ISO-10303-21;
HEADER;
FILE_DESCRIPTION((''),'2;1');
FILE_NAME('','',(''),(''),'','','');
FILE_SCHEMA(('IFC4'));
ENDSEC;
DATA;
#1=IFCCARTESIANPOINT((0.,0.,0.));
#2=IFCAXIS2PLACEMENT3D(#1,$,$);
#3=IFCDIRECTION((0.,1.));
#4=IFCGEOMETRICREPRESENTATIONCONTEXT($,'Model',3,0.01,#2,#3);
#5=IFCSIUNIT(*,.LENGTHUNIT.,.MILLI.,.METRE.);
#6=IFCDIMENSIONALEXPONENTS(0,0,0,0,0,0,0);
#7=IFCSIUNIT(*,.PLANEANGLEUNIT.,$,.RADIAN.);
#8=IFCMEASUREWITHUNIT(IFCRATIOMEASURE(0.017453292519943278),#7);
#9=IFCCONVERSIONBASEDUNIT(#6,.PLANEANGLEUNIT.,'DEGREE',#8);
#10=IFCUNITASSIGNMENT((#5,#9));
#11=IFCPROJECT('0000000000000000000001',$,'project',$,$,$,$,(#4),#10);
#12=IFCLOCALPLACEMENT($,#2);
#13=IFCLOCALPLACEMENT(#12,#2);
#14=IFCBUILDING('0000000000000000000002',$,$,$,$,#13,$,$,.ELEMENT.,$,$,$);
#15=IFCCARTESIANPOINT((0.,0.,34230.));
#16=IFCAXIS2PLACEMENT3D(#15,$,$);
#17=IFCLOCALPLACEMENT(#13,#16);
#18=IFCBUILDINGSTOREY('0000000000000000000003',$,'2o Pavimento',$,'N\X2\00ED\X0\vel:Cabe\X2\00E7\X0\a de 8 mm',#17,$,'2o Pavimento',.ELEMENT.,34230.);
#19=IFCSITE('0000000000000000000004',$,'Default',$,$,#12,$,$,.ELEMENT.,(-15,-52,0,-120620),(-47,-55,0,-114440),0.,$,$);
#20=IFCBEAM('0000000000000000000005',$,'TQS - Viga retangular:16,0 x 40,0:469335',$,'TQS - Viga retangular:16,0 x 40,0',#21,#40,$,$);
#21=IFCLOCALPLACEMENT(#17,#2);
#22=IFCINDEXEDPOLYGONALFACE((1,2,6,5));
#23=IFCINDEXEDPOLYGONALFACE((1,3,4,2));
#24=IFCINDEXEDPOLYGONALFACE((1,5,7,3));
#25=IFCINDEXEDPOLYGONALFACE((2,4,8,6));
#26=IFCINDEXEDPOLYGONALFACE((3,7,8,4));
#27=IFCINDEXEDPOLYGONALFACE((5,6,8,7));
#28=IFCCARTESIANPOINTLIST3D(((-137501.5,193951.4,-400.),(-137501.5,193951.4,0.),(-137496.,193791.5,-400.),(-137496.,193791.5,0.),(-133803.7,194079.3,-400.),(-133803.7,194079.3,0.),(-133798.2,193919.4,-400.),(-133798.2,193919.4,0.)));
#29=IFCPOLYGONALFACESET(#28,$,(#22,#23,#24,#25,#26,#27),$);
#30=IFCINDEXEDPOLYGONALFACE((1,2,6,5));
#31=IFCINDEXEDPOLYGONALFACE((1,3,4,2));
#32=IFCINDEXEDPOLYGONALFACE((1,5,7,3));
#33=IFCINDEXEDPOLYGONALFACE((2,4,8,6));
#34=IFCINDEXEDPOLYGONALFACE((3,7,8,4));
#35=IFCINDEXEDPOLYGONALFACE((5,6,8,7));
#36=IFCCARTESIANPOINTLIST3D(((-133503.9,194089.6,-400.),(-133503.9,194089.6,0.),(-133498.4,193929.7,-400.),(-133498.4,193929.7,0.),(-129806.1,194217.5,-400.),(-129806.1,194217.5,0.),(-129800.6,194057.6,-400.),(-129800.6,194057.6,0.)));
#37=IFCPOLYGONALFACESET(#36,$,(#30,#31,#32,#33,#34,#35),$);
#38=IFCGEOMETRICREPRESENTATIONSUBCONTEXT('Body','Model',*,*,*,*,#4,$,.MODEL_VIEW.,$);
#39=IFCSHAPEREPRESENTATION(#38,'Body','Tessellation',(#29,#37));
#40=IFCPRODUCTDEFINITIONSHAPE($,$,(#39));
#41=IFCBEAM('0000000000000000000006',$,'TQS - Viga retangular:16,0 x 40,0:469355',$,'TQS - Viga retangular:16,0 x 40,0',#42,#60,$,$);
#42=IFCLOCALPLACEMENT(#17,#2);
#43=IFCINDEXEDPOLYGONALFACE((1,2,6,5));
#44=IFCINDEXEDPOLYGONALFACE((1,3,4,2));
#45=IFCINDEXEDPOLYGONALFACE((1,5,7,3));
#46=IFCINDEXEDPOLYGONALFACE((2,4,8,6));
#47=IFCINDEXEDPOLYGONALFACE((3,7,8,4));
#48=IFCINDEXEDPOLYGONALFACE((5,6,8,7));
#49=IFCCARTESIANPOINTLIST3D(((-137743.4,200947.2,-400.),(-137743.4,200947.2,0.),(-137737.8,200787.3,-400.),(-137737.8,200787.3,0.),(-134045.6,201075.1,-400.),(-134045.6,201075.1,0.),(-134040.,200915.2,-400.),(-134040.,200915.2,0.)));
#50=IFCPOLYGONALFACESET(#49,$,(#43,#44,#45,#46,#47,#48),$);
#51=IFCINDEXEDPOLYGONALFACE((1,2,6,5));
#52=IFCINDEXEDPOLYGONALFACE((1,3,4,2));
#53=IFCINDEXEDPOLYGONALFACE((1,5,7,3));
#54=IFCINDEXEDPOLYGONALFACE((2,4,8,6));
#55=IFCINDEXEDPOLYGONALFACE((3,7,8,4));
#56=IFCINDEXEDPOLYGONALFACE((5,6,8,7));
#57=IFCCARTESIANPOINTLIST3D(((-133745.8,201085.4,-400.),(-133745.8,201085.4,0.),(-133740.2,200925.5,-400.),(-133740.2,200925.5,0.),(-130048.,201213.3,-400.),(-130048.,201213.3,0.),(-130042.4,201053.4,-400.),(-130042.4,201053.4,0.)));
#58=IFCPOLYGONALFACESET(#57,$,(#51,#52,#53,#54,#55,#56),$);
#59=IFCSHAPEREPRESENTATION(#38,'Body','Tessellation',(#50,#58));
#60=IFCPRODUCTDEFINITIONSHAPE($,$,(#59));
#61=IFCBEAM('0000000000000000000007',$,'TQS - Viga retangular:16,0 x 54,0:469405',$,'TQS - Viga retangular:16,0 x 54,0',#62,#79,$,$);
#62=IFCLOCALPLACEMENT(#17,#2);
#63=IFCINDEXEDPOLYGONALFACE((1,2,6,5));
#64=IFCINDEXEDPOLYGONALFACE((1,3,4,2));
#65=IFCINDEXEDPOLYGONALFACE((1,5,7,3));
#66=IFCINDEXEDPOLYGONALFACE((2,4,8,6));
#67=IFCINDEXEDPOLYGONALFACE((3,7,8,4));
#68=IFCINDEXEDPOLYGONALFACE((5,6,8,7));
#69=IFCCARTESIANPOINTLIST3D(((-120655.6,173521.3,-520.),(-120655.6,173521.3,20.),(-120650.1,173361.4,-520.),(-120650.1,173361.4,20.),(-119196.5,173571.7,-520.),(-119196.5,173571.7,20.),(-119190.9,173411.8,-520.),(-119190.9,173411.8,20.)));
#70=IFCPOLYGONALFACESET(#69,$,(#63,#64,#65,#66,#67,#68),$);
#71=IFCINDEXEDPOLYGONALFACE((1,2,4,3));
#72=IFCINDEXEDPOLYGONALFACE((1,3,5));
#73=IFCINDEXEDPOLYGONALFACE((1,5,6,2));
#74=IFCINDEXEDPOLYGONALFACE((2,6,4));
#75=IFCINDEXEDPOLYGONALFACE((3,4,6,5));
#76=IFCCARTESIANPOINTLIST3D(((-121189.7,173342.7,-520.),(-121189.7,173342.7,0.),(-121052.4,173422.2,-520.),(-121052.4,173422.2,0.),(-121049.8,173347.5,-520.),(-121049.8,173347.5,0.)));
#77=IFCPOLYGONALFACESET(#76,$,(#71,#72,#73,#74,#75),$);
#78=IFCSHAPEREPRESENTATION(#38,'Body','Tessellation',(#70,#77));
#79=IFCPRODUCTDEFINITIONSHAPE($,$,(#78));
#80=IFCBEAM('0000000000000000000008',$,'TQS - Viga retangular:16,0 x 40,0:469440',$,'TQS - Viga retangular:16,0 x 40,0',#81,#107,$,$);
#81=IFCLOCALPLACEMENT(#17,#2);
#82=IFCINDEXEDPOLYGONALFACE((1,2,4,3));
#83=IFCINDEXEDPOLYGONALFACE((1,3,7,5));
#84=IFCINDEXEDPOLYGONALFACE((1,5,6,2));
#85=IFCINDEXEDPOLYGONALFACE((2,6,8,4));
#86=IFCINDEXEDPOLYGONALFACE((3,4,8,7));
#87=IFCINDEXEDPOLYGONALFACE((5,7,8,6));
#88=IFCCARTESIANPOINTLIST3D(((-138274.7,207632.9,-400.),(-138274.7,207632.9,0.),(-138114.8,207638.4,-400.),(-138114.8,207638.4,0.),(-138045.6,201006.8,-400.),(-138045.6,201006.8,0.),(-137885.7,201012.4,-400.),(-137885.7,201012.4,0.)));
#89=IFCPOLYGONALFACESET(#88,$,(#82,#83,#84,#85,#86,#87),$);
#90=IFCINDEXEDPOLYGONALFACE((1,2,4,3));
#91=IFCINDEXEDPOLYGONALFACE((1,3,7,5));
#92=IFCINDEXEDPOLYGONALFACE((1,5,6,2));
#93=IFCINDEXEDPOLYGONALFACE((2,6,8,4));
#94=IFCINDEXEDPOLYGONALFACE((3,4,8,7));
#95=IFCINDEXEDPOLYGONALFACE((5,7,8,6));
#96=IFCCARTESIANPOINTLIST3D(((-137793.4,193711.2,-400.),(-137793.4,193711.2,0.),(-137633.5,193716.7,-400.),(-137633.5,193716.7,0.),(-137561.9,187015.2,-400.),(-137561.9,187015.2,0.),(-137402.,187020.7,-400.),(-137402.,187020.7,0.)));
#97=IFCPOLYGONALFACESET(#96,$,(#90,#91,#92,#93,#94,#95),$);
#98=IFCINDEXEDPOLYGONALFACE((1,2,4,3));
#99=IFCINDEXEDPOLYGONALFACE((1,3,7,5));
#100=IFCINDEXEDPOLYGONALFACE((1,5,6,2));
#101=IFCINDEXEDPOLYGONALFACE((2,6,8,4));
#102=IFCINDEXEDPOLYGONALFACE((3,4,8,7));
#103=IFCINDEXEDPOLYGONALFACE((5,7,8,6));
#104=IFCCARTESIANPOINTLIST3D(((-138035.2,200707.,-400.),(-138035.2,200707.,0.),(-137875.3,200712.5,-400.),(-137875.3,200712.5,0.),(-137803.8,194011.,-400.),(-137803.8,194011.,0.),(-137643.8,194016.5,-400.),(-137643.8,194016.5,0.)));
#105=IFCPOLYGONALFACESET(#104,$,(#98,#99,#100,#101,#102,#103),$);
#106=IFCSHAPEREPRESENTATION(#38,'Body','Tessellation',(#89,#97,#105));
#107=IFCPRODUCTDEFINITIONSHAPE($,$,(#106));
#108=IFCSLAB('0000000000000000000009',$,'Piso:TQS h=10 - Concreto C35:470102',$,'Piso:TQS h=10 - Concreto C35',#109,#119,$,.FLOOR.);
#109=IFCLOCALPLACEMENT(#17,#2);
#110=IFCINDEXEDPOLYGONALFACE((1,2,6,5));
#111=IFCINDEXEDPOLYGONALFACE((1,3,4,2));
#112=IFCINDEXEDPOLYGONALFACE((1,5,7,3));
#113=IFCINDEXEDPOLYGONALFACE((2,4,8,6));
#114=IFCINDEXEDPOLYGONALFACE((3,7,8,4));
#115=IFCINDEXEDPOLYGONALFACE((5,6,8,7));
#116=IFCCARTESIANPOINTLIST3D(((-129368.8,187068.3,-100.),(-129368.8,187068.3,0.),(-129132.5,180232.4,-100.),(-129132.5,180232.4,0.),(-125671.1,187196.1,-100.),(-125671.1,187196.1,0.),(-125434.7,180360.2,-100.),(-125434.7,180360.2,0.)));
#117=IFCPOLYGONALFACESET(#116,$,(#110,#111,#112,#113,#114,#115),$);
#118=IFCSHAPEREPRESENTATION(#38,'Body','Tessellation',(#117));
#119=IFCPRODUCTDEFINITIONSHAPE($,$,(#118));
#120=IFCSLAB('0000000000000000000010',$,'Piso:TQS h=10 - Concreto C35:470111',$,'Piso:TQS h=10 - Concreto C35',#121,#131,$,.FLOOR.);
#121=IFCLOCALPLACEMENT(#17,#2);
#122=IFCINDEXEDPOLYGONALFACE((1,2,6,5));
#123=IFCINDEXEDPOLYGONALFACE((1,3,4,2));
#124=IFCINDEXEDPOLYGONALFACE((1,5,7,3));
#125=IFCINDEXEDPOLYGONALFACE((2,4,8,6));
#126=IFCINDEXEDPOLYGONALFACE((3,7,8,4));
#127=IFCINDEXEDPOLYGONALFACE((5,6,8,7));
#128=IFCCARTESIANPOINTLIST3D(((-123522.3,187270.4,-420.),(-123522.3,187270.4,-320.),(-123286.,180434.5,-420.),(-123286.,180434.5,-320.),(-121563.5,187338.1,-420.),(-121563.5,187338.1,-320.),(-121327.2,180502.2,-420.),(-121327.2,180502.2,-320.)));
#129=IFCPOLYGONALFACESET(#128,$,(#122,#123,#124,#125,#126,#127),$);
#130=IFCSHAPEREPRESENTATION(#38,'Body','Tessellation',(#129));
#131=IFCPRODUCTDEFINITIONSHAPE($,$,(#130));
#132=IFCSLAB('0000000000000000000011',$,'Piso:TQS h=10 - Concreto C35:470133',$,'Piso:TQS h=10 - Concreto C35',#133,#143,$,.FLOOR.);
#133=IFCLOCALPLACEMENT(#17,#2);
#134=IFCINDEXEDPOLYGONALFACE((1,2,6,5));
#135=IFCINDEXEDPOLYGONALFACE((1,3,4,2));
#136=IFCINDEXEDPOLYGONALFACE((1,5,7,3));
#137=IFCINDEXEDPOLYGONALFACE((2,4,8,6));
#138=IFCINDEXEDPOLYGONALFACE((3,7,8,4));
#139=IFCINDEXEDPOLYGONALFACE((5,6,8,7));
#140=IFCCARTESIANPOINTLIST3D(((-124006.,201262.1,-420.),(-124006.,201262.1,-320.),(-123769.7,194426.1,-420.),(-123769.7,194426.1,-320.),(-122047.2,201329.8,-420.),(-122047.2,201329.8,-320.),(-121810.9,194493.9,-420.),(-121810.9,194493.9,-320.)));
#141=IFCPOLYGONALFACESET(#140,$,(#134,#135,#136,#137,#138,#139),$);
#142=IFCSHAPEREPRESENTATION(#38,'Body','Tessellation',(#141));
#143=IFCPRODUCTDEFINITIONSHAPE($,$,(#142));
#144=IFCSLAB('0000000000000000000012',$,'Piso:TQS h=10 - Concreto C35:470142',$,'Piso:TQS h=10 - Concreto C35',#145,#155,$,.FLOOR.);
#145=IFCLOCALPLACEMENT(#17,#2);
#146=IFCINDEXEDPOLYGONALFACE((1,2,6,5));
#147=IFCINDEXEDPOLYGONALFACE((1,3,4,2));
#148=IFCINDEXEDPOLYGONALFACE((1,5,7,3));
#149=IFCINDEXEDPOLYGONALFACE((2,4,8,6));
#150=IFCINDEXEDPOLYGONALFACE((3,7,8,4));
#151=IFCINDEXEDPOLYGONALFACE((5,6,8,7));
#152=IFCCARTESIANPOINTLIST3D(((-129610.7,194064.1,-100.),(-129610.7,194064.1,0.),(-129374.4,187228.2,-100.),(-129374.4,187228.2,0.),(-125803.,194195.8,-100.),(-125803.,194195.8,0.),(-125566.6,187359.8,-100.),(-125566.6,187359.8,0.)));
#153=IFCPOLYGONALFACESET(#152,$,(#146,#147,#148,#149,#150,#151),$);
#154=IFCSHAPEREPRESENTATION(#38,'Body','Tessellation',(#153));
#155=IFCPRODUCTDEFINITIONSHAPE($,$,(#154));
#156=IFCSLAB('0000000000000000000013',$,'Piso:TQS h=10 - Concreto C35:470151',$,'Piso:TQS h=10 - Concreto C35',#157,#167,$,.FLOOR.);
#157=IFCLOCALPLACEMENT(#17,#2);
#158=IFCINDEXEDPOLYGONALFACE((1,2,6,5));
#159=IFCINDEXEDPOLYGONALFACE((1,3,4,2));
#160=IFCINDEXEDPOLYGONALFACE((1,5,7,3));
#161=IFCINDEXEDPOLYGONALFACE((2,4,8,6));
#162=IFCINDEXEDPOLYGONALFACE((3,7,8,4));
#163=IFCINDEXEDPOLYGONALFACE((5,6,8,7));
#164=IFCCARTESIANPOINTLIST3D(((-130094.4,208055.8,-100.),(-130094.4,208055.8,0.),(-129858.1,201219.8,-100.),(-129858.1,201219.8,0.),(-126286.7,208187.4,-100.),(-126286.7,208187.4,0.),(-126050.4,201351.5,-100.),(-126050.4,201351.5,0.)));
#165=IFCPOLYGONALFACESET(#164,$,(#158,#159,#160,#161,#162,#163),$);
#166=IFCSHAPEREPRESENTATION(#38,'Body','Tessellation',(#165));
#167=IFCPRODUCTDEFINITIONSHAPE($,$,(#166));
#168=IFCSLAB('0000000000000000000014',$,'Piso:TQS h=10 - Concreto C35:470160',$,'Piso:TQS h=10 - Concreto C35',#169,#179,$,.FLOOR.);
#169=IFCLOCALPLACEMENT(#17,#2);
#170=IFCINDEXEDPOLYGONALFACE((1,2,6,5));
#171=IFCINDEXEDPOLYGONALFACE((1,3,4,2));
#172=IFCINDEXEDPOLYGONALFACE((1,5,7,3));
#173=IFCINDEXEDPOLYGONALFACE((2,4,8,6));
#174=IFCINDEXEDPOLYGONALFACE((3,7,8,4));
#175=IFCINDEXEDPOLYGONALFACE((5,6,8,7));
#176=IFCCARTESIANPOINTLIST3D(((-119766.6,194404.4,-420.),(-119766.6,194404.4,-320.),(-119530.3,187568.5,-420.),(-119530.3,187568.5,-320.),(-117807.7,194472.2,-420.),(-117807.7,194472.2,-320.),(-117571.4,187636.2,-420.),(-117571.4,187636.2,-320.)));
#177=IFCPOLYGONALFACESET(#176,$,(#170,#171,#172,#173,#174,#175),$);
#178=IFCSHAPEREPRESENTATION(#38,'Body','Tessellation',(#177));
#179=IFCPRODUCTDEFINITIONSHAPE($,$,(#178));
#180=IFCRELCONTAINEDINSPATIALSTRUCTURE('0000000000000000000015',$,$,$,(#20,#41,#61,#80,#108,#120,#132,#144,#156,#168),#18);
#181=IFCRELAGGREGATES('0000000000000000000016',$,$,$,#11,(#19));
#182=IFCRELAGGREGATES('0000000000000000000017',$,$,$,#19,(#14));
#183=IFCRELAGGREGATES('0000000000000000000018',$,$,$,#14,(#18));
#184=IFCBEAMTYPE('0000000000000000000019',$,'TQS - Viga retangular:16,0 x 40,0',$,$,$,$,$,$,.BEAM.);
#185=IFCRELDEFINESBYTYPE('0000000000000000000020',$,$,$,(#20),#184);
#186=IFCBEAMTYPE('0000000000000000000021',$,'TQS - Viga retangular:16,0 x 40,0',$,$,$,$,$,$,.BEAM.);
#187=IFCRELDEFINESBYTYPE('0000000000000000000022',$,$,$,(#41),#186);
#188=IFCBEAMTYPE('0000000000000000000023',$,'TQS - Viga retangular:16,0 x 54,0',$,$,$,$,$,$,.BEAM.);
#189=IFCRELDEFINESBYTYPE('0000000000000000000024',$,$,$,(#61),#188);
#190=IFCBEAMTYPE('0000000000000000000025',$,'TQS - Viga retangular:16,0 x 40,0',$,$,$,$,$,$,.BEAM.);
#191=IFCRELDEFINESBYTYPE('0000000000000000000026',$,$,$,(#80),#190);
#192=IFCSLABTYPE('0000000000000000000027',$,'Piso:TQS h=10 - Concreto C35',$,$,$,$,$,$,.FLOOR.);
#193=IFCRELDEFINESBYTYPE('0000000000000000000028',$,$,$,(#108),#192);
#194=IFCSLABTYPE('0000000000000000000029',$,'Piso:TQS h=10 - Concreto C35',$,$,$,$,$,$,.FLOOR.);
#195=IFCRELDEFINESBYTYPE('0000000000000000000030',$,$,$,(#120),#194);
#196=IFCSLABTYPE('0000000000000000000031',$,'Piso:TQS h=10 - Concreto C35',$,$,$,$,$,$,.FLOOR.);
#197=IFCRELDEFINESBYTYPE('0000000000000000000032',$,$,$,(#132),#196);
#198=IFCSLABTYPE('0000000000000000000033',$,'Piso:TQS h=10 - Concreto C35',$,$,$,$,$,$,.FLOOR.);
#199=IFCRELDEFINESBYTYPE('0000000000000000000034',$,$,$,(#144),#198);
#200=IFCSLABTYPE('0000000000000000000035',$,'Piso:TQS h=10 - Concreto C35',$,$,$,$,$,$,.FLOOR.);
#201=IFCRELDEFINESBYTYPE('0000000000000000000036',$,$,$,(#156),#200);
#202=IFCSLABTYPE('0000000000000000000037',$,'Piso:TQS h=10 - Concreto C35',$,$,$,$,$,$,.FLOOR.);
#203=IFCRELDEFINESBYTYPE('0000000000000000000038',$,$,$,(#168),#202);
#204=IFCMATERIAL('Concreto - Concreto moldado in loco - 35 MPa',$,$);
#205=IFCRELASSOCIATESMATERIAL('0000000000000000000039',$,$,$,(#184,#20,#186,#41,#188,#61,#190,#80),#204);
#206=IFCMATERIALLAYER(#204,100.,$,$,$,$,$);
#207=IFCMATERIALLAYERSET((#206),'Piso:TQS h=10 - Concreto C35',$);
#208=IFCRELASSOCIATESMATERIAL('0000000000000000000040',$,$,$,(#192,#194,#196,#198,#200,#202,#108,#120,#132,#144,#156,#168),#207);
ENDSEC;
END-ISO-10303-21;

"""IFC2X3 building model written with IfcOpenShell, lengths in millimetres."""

from ifc_helpers import new_model, entity, si_unit, converted_unit, direction, frame, frame_2d, origin, place, context, subcontext, project, spatial, rectangle, extrude, clip, halfspace, source, transform, mapped, material, layer, layer_set, layer_usage, type_object, type_shapes, element, save


model = new_model("IFC2X3")

# Units and contexts
model_context = context("Model", 3, precision=0.01, world=origin(), true_north=direction((0.0, 1.0)))
body_context = subcontext(model_context, "Body", "Model", "MODEL_VIEW")
ifc_project = project(units=[si_unit("LENGTHUNIT", "METRE", prefix="MILLI"), converted_unit("PLANEANGLEUNIT", "DEGREE", entity("IfcRatioMeasure", 0.017453292519943278), si_unit("PLANEANGLEUNIT", "RADIAN"), dimensions=[0, 0, 0, 0, 0, 0, 0])], contexts=[model_context])

# Site, building, storey
site_placement = place(None, origin())
site = spatial("IfcSite", under=ifc_project, at=site_placement, Name="Default", CompositionType="ELEMENT", RefLatitude=(-15, -52, 0, -120620), RefLongitude=(-47, -55, 0, -114440), RefElevation=0.0)
building_placement = place(site_placement, origin())
building = spatial("IfcBuilding", under=site, at=building_placement, CompositionType="ELEMENT")
storey_placement = place(building_placement, frame((0.0, 0.0, 34230.0)))
storey = spatial("IfcBuildingStorey", under=building, at=storey_placement, Name="2o Pavimento", ObjectType="Nível:Cabeça de 8 mm", LongName="2o Pavimento", CompositionType="ELEMENT", Elevation=34230.0)

# Beams
ifc_material = material(Name="Concreto - Concreto moldado in loco - 35 MPa")
beam_type_1 = type_object("IfcBeamType", Name="TQS - Viga retangular:16,0 x 40,0", PredefinedType="BEAM", material=ifc_material)
shared_shape_1 = source(origin(), body_context, "Body", "SweptSolid", [
    extrude(rectangle(XDim=400.0, YDim=160.0, at=frame_2d((0.0, 0.0), x_axis=(1.0, 0.0))), frame((-133801.0, 193999.3, 34030.0), z_axis=(-0.999403, -0.034551, 0.0), x_axis=(0.0, 0.0, -1.0)), (0.0, 0.0, 1.0), 3700.0),
    extrude(rectangle(XDim=400.0, YDim=160.0, at=frame_2d((0.0, 0.0), x_axis=(1.0, 0.0))), frame((-129803.3, 194137.5, 34030.0), z_axis=(-0.999403, -0.034551, 0.0), x_axis=(0.0, 0.0, -1.0)), (0.0, 0.0, 1.0), 3700.0),
])
type_shapes(beam_type_1, [shared_shape_1])
beam_1_placement = place(storey_placement, frame((0.0, 0.0, -34230.0)))
element("IfcBeam", 1, at=beam_1_placement, inside=storey, type_object=beam_type_1, material=ifc_material, Name="TQS - Viga retangular:16,0 x 40,0:469335", ObjectType="TQS - Viga retangular:16,0 x 40,0", context=body_context, shape_type="MappedRepresentation", body=[
    mapped(shared_shape_1, transform((0.0, 0.0, 0.0), scale=1.0)),
])
beam_type_2 = type_object("IfcBeamType", Name="TQS - Viga retangular:16,0 x 40,0", PredefinedType="BEAM", material=ifc_material)
shared_shape_2 = source(origin(), body_context, "Body", "SweptSolid", [
    extrude(rectangle(XDim=400.0, YDim=160.0, at=frame_2d((0.0, 0.0), x_axis=(1.0, 0.0))), frame((-134042.8, 200995.1, 34030.0), z_axis=(-0.999403, -0.034551, 0.0), x_axis=(0.0, 0.0, -1.0)), (0.0, 0.0, 1.0), 3700.0),
    extrude(rectangle(XDim=400.0, YDim=160.0, at=frame_2d((0.0, 0.0), x_axis=(1.0, 0.0))), frame((-130045.2, 201133.3, 34030.0), z_axis=(-0.999403, -0.034551, 0.0), x_axis=(0.0, 0.0, -1.0)), (0.0, 0.0, 1.0), 3700.0),
])
type_shapes(beam_type_2, [shared_shape_2])
beam_2_placement = place(storey_placement, frame((0.0, 0.0, -34230.0)))
element("IfcBeam", 2, at=beam_2_placement, inside=storey, type_object=beam_type_2, material=ifc_material, Name="TQS - Viga retangular:16,0 x 40,0:469355", ObjectType="TQS - Viga retangular:16,0 x 40,0", context=body_context, shape_type="MappedRepresentation", body=[
    mapped(shared_shape_2, transform((0.0, 0.0, 0.0), scale=1.0)),
])
beam_type_3 = type_object("IfcBeamType", Name="TQS - Viga retangular:16,0 x 54,0", PredefinedType="BEAM", material=ifc_material)
shared_shape_3 = source(origin(), body_context, "Body", "SweptSolid", [
    extrude(rectangle(XDim=540.0, YDim=160.0, at=frame_2d((0.0, 0.0), x_axis=(1.0, 0.0))), frame((-119193.7, 173491.8, 33980.0), z_axis=(-0.999403, -0.034551, 0.0), x_axis=(0.0, 0.0, -1.0)), (0.0, 0.0, 1.0), 1460.0),
    clip(extrude(rectangle(XDim=520.0, YDim=74.7, at=frame_2d((0.0, 0.0), x_axis=(0.0, 1.0))), frame((-121051.1, 173384.8, 33970.0), z_axis=(-0.999403, -0.034551, 0.0), x_axis=(0.034551, -0.999403, 0.0)), (0.0, 0.0, 1.0), 140.0), halfspace(frame((-120895.4, 173513.0, 34250.0), z_axis=(-0.500793, 0.865567, 0.0), x_axis=(0.865567, 0.500793, 0.0)), False)),
])
type_shapes(beam_type_3, [shared_shape_3])
beam_3_placement = place(storey_placement, frame((0.0, 0.0, -34230.0)))
element("IfcBeam", 3, at=beam_3_placement, inside=storey, type_object=beam_type_3, material=ifc_material, Name="TQS - Viga retangular:16,0 x 54,0:469405", ObjectType="TQS - Viga retangular:16,0 x 54,0", context=body_context, shape_type="MappedRepresentation", body=[
    mapped(shared_shape_3, transform((0.0, 0.0, 0.0), scale=1.0)),
])
beam_type_4 = type_object("IfcBeamType", Name="TQS - Viga retangular:16,0 x 40,0", PredefinedType="BEAM", material=ifc_material)
shared_shape_4 = source(origin(), body_context, "Body", "SweptSolid", [
    extrude(rectangle(XDim=400.0, YDim=160.0, at=frame_2d((0.0, 0.0), x_axis=(1.0, 0.0))), frame((-137965.7, 201009.6, 34030.0), z_axis=(-0.034551, 0.999403, 0.0), x_axis=(0.0, 0.0, 1.0)), (0.0, 0.0, 1.0), 6630.0),
    extrude(rectangle(XDim=400.0, YDim=160.0, at=frame_2d((0.0, 0.0), x_axis=(1.0, 0.0))), frame((-137481.9, 187018.0, 34030.0), z_axis=(-0.034551, 0.999403, 0.0), x_axis=(0.0, 0.0, 1.0)), (0.0, 0.0, 1.0), 6700.0),
    extrude(rectangle(XDim=400.0, YDim=160.0, at=frame_2d((0.0, 0.0), x_axis=(1.0, 0.0))), frame((-137723.8, 194013.8, 34030.0), z_axis=(-0.034551, 0.999403, 0.0), x_axis=(0.0, 0.0, 1.0)), (0.0, 0.0, 1.0), 6700.0),
])
type_shapes(beam_type_4, [shared_shape_4])
beam_4_placement = place(storey_placement, frame((0.0, 0.0, -34230.0)))
element("IfcBeam", 4, at=beam_4_placement, inside=storey, type_object=beam_type_4, material=ifc_material, Name="TQS - Viga retangular:16,0 x 40,0:469440", ObjectType="TQS - Viga retangular:16,0 x 40,0", context=body_context, shape_type="MappedRepresentation", body=[
    mapped(shared_shape_4, transform((0.0, 0.0, 0.0), scale=1.0)),
])

# Slabs
ifc_layer = layer(ifc_material, 100.0)
ifc_layer_set = layer_set([ifc_layer], Name="Piso:TQS h=10 - Concreto C35")
ifc_layer_usage_1 = layer_usage(ifc_layer_set, "AXIS3", "POSITIVE", 0.0)
slab_type_1 = type_object("IfcSlabType", Name="Piso:TQS h=10 - Concreto C35", PredefinedType="FLOOR", material=ifc_layer_set)
slab_1_placement = place(storey_placement, origin())
element("IfcSlab", 5, at=slab_1_placement, inside=storey, type_object=slab_type_1, material=ifc_layer_usage_1, Name="Piso:TQS h=10 - Concreto C35:470102", ObjectType="Piso:TQS h=10 - Concreto C35", PredefinedType="FLOOR", context=body_context, shape_type="SweptSolid", body=[
    extrude(rectangle(XDim=6840.0, YDim=3700.0, at=frame_2d((0.0, 0.0), x_axis=(1.0, 0.0))), frame((-127401.8, 183714.3, 0.0), z_axis=(0.0, 0.0, -1.0), x_axis=(0.034551, -0.999403, 0.0)), (0.0, 0.0, 1.0), 100.0),
])
ifc_layer_usage_2 = layer_usage(ifc_layer_set, "AXIS3", "POSITIVE", 0.0)
slab_type_2 = type_object("IfcSlabType", Name="Piso:TQS h=10 - Concreto C35", PredefinedType="FLOOR", material=ifc_layer_set)
slab_2_placement = place(storey_placement, origin())
element("IfcSlab", 6, at=slab_2_placement, inside=storey, type_object=slab_type_2, material=ifc_layer_usage_2, Name="Piso:TQS h=10 - Concreto C35:470111", ObjectType="Piso:TQS h=10 - Concreto C35", PredefinedType="FLOOR", context=body_context, shape_type="SweptSolid", body=[
    extrude(rectangle(XDim=6840.0, YDim=1960.0, at=frame_2d((0.0, 0.0), x_axis=(1.0, 0.0))), frame((-122424.8, 183886.3, -320.0), z_axis=(0.0, 0.0, -1.0), x_axis=(0.034551, -0.999403, 0.0)), (0.0, 0.0, 1.0), 100.0),
])
ifc_layer_usage_3 = layer_usage(ifc_layer_set, "AXIS3", "POSITIVE", 0.0)
slab_type_3 = type_object("IfcSlabType", Name="Piso:TQS h=10 - Concreto C35", PredefinedType="FLOOR", material=ifc_layer_set)
slab_3_placement = place(storey_placement, origin())
element("IfcSlab", 7, at=slab_3_placement, inside=storey, type_object=slab_type_3, material=ifc_layer_usage_3, Name="Piso:TQS h=10 - Concreto C35:470133", ObjectType="Piso:TQS h=10 - Concreto C35", PredefinedType="FLOOR", context=body_context, shape_type="SweptSolid", body=[
    extrude(rectangle(XDim=6840.0, YDim=1960.0, at=frame_2d((0.0, 0.0), x_axis=(1.0, 0.0))), frame((-122908.5, 197878.0, -320.0), z_axis=(0.0, 0.0, -1.0), x_axis=(0.034551, -0.999403, 0.0)), (0.0, 0.0, 1.0), 100.0),
])
ifc_layer_usage_4 = layer_usage(ifc_layer_set, "AXIS3", "POSITIVE", 0.0)
slab_type_4 = type_object("IfcSlabType", Name="Piso:TQS h=10 - Concreto C35", PredefinedType="FLOOR", material=ifc_layer_set)
slab_4_placement = place(storey_placement, origin())
element("IfcSlab", 8, at=slab_4_placement, inside=storey, type_object=slab_type_4, material=ifc_layer_usage_4, Name="Piso:TQS h=10 - Concreto C35:470142", ObjectType="Piso:TQS h=10 - Concreto C35", PredefinedType="FLOOR", context=body_context, shape_type="SweptSolid", body=[
    extrude(rectangle(XDim=6840.0, YDim=3810.0, at=frame_2d((0.0, 0.0), x_axis=(1.0, 0.0))), frame((-127588.7, 190712.0, 0.0), z_axis=(0.0, 0.0, -1.0), x_axis=(0.034551, -0.999403, 0.0)), (0.0, 0.0, 1.0), 100.0),
])
ifc_layer_usage_5 = layer_usage(ifc_layer_set, "AXIS3", "POSITIVE", 0.0)
slab_type_5 = type_object("IfcSlabType", Name="Piso:TQS h=10 - Concreto C35", PredefinedType="FLOOR", material=ifc_layer_set)
slab_5_placement = place(storey_placement, origin())
element("IfcSlab", 9, at=slab_5_placement, inside=storey, type_object=slab_type_5, material=ifc_layer_usage_5, Name="Piso:TQS h=10 - Concreto C35:470151", ObjectType="Piso:TQS h=10 - Concreto C35", PredefinedType="FLOOR", context=body_context, shape_type="SweptSolid", body=[
    extrude(rectangle(XDim=6840.0, YDim=3810.0, at=frame_2d((0.0, 0.0), x_axis=(1.0, 0.0))), frame((-128072.4, 204703.6, 0.0), z_axis=(0.0, 0.0, -1.0), x_axis=(0.034551, -0.999403, 0.0)), (0.0, 0.0, 1.0), 100.0),
])
ifc_layer_usage_6 = layer_usage(ifc_layer_set, "AXIS3", "POSITIVE", 0.0)
slab_type_6 = type_object("IfcSlabType", Name="Piso:TQS h=10 - Concreto C35", PredefinedType="FLOOR", material=ifc_layer_set)
slab_6_placement = place(storey_placement, origin())
element("IfcSlab", 10, at=slab_6_placement, inside=storey, type_object=slab_type_6, material=ifc_layer_usage_6, Name="Piso:TQS h=10 - Concreto C35:470160", ObjectType="Piso:TQS h=10 - Concreto C35", PredefinedType="FLOOR", context=body_context, shape_type="SweptSolid", body=[
    extrude(rectangle(XDim=6840.0, YDim=1960.0, at=frame_2d((0.0, 0.0), x_axis=(1.0, 0.0))), frame((-118669.0, 191020.3, -320.0), z_axis=(0.0, 0.0, -1.0), x_axis=(0.034551, -0.999403, 0.0)), (0.0, 0.0, 1.0), 100.0),
])

save(model, "model.ifc")
